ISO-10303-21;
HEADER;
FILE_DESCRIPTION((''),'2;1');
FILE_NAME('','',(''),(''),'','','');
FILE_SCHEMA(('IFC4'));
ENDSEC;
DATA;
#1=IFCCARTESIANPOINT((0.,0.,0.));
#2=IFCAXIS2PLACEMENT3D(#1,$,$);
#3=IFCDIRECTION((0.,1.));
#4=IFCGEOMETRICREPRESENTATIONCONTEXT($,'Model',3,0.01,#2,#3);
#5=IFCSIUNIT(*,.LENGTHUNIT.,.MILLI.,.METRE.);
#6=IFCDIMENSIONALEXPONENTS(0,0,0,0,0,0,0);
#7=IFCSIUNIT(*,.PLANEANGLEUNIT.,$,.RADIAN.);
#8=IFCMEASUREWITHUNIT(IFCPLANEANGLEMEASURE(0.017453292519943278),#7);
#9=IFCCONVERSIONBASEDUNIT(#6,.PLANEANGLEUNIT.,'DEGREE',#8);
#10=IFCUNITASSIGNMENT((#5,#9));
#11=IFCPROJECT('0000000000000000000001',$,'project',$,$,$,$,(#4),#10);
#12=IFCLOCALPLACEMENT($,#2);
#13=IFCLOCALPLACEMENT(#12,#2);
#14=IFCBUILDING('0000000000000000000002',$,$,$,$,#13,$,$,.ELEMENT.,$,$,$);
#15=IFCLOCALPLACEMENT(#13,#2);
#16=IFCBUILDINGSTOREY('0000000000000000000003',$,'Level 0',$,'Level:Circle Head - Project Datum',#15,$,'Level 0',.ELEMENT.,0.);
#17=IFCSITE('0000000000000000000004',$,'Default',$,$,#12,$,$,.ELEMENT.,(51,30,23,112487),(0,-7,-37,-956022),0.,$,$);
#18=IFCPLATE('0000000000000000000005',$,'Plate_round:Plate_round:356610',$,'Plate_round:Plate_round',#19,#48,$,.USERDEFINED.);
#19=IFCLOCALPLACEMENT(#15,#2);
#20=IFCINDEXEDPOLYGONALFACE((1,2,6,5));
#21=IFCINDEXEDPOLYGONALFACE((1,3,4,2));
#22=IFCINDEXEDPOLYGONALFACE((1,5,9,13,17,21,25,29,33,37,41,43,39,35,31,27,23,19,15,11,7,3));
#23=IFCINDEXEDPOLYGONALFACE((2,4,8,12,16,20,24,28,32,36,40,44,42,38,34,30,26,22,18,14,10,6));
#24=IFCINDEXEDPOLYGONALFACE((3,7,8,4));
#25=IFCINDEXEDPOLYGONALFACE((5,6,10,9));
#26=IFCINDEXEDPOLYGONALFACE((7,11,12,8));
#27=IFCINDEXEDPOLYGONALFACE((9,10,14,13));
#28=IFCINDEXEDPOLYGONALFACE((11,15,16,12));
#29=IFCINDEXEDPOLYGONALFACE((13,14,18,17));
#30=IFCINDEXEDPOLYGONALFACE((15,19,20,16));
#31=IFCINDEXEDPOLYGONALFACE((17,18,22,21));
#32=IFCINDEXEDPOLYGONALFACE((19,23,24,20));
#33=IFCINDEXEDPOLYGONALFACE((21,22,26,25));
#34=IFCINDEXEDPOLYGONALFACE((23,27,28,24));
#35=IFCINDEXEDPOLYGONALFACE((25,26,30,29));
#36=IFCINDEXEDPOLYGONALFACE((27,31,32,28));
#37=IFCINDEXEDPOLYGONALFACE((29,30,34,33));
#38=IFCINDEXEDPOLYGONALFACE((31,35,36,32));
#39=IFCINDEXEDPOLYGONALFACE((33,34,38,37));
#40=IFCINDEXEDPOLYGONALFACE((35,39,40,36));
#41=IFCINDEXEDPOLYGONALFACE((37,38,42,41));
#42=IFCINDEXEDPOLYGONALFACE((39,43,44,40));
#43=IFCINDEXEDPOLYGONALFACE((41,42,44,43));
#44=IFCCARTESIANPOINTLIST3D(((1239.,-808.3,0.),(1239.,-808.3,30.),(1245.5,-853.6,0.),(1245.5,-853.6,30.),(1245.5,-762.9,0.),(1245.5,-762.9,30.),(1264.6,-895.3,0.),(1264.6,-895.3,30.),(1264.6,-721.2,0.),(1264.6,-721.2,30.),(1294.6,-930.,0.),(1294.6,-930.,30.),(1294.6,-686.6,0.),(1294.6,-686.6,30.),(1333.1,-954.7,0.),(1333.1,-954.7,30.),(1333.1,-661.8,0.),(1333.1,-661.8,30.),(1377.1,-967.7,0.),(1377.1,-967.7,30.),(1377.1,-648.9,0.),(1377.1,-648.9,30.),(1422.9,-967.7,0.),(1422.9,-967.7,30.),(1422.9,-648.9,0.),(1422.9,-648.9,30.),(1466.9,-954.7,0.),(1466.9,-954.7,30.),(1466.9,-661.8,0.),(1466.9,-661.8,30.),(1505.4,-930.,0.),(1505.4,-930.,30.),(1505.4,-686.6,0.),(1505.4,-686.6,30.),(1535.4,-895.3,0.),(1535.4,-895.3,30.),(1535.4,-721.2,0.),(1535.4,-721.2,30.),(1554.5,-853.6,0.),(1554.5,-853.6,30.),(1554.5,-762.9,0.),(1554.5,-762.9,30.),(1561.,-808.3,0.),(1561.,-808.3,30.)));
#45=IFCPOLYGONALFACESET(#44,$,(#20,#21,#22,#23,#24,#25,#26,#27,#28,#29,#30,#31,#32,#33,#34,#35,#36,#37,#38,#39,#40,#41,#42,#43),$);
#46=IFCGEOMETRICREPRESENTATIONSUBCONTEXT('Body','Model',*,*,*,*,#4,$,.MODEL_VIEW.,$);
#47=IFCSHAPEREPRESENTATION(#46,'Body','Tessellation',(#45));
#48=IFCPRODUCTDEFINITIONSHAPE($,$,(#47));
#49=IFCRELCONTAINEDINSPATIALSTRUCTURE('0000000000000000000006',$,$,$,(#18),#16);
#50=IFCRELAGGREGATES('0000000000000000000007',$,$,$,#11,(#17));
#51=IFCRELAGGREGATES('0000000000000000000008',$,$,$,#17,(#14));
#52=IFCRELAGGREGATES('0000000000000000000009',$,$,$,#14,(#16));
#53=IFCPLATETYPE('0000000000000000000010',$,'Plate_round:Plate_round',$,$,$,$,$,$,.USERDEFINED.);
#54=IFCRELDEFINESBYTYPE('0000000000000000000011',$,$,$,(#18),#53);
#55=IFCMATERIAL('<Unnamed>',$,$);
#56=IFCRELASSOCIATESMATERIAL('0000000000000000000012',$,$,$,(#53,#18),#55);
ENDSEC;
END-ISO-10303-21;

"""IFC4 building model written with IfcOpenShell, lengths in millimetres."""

from ifc_helpers import new_model, entity, si_unit, converted_unit, direction, frame, origin, place, context, subcontext, project, spatial, arc, indexed_curve, outline, extrude, source, transform, mapped, material, type_object, type_shapes, element, save


model = new_model("IFC4")

# Units and contexts
model_context = context("Model", 3, precision=0.01, world=origin(), true_north=direction((0.0, 1.0)))
body_context = subcontext(model_context, "Body", "Model", "MODEL_VIEW")
ifc_project = project(units=[si_unit("LENGTHUNIT", "METRE", prefix="MILLI"), converted_unit("PLANEANGLEUNIT", "DEGREE", entity("IfcPlaneAngleMeasure", 0.017453292519943278), si_unit("PLANEANGLEUNIT", "RADIAN"), dimensions=[0, 0, 0, 0, 0, 0, 0])], contexts=[model_context])

# Site, building, storey
site_placement = place(None, origin())
site = spatial("IfcSite", under=ifc_project, at=site_placement, Name="Default", CompositionType="ELEMENT", RefLatitude=(51, 30, 23, 112487), RefLongitude=(0, -7, -37, -956022), RefElevation=0.0)
building_placement = place(site_placement, origin())
building = spatial("IfcBuilding", under=site, at=building_placement, CompositionType="ELEMENT")
storey_placement = place(building_placement, origin())
storey = spatial("IfcBuildingStorey", under=building, at=storey_placement, Name="Level 0", ObjectType="Level:Circle Head - Project Datum", LongName="Level 0", CompositionType="ELEMENT", Elevation=0.0)

# Plate
ifc_material_1 = material(Name="<Unnamed>")
plate_type = type_object("IfcPlateType", Name="Plate_round:Plate_round", PredefinedType="USERDEFINED", material=ifc_material_1)
shared_shape = source(origin(), body_context, "Body", "SweptSolid", [
    extrude(outline(indexed_curve([(-161.0, 0.0), (0.0, -161.0), (161.0, 0.0), (0.0, 161.0)], segments=[arc(1, 2, 3), arc(3, 4, 1)], self_intersect=False)), origin(), (0.0, 0.0, 1.0), 30.0),
])
type_shapes(plate_type, [shared_shape])
plate_placement = place(storey_placement, frame((1400.0, -808.3, 0.0)))
element("IfcPlate", 1, at=plate_placement, inside=storey, type_object=plate_type, material=ifc_material_1, Name="Plate_round:Plate_round:356610", ObjectType="Plate_round:Plate_round", PredefinedType="USERDEFINED", context=body_context, shape_type="MappedRepresentation", body=[
    mapped(shared_shape, transform((0.0, 0.0, 0.0), scale=1.0)),
])

save(model, "model.ifc")
